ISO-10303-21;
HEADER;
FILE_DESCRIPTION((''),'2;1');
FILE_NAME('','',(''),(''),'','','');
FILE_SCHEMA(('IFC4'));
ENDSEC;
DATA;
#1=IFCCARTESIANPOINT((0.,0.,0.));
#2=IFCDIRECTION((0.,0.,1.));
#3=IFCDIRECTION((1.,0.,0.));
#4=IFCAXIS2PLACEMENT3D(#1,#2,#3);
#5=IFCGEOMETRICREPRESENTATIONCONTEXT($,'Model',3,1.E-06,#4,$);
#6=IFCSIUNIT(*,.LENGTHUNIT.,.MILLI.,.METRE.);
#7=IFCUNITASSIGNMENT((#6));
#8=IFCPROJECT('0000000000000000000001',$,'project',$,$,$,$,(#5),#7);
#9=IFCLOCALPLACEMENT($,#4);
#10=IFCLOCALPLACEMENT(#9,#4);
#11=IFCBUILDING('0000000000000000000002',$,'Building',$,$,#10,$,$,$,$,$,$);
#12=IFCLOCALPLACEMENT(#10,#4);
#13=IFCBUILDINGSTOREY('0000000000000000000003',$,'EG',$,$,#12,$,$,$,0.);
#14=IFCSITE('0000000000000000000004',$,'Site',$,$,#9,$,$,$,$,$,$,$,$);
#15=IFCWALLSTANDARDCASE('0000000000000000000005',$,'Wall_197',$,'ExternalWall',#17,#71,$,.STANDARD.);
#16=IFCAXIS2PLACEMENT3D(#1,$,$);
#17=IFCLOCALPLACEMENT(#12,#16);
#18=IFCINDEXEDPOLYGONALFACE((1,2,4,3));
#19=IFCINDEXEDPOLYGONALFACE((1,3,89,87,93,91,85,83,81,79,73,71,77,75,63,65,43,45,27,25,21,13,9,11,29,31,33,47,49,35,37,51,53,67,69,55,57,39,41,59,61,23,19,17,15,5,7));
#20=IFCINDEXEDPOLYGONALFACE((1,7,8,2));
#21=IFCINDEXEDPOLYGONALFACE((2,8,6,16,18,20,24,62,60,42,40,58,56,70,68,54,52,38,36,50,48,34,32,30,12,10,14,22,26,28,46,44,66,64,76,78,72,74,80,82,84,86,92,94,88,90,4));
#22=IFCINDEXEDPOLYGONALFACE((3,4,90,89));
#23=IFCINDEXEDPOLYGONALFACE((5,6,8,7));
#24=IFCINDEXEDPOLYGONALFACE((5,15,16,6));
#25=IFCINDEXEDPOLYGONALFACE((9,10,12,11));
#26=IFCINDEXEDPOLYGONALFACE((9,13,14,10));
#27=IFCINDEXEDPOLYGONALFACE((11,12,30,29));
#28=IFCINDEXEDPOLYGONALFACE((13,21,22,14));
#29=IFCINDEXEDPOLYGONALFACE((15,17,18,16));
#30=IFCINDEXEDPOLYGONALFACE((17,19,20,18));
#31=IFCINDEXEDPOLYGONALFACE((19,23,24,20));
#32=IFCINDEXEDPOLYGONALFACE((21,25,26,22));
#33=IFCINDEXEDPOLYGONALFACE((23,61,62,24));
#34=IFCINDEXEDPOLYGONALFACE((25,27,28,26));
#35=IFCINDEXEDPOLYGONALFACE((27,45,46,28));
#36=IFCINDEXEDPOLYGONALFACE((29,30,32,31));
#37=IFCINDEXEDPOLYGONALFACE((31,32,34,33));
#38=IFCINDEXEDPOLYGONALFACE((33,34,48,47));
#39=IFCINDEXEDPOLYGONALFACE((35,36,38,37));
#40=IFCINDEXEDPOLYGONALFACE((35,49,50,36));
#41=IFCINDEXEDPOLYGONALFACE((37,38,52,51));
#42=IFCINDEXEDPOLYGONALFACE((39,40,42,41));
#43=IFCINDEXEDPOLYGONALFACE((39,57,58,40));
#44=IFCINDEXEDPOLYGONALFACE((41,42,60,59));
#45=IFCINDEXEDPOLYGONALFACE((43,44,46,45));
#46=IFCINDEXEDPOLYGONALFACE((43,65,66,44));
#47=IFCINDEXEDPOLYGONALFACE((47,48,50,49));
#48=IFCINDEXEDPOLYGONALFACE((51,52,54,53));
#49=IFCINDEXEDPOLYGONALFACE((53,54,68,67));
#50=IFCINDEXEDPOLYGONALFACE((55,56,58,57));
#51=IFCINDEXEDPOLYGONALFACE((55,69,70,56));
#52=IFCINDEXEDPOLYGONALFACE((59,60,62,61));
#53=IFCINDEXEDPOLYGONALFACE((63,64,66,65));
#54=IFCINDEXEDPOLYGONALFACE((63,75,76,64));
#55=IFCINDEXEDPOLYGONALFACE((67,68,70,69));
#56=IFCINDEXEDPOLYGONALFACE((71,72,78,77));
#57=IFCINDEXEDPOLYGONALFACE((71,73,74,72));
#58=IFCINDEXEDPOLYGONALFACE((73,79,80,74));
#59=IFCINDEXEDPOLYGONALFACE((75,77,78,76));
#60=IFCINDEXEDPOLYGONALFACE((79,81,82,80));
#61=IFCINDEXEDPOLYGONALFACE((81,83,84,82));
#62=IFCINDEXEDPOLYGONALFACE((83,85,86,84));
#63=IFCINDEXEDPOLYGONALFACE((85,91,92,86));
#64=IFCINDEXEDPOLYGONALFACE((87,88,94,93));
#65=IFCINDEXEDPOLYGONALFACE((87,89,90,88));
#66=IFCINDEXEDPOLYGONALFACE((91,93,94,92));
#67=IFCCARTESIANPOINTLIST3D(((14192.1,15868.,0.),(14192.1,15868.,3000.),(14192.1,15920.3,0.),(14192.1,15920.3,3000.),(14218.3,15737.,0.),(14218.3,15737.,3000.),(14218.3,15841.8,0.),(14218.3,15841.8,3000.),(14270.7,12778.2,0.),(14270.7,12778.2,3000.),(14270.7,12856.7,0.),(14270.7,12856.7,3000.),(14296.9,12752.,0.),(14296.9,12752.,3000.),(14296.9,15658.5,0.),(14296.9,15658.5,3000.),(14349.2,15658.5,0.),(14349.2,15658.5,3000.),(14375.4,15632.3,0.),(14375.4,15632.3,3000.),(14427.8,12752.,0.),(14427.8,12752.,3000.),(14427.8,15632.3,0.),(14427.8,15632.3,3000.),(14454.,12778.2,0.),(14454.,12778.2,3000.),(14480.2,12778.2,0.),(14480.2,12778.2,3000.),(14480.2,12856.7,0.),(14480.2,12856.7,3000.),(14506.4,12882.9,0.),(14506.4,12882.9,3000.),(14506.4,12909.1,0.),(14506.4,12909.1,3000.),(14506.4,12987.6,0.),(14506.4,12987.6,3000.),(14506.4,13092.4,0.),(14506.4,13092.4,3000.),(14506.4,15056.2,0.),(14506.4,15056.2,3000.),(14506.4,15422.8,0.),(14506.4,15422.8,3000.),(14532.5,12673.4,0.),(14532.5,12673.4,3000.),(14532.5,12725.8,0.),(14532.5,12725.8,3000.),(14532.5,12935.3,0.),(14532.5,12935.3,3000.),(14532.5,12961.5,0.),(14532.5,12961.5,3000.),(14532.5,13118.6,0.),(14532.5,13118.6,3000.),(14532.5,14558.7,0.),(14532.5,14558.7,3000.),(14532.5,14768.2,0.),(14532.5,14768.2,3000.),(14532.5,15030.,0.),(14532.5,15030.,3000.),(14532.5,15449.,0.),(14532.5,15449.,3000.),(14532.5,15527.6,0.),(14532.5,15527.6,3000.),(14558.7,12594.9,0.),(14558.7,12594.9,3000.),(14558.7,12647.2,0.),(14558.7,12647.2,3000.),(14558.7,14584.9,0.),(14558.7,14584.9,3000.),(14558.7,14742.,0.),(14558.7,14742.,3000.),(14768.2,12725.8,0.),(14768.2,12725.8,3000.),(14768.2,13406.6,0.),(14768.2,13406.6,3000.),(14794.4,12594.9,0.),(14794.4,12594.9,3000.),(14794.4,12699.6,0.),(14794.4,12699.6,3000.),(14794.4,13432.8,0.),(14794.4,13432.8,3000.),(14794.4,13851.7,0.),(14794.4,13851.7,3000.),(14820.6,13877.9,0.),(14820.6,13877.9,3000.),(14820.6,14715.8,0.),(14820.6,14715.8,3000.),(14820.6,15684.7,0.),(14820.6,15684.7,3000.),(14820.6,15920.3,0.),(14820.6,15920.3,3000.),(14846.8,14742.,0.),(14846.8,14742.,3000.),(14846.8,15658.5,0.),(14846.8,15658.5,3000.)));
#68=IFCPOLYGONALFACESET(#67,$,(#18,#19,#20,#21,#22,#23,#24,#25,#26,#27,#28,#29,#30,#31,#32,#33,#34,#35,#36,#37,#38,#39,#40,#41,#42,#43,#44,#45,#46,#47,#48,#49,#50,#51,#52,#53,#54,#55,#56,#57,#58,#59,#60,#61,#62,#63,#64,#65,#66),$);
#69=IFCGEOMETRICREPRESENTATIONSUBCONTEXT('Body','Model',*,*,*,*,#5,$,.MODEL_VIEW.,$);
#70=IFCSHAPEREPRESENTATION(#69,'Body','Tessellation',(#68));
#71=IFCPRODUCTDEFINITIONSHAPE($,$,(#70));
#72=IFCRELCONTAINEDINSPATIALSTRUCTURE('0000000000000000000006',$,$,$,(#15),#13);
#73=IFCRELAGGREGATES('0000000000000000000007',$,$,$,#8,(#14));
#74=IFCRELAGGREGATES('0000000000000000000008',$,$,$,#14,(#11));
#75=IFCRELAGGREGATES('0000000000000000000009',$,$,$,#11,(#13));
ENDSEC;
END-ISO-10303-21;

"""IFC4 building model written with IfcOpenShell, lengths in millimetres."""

from ifc_helpers import new_model, si_unit, origin_with_axes, place, context, subcontext, project, spatial, polyline, outline, extrude, element, save


model = new_model("IFC4")

# Units and contexts
model_context = context("Model", 3, precision=1e-06, world=origin_with_axes())
body_context = subcontext(model_context, "Body", "Model", "MODEL_VIEW")
ifc_project = project(units=[si_unit("LENGTHUNIT", "METRE", prefix="MILLI")], contexts=[model_context])

# Site, building, storey
site_placement = place(None, origin_with_axes())
site = spatial("IfcSite", under=ifc_project, at=site_placement, Name="Site")
building_placement = place(site_placement, origin_with_axes())
building = spatial("IfcBuilding", under=site, at=building_placement, Name="Building")
storey_placement = place(building_placement, origin_with_axes())
storey = spatial("IfcBuildingStorey", under=building, at=storey_placement, Name="EG", Elevation=0.0)

# Wall
wall_1_placement = place(storey_placement, origin_with_axes())
element("IfcWallStandardCase", 1, at=wall_1_placement, inside=storey, Name="Wall_197", ObjectType="ExternalWall", PredefinedType="STANDARD", context=body_context, shape_type="SweptSolid", body=[
    extrude(outline(polyline([(14558.7, 12594.9, 0.0), (14558.7, 12647.2, 0.0), (14532.5, 12673.4, 0.0), (14532.5, 12725.8, 0.0), (14480.2, 12778.2, 0.0), (14454.0, 12778.2, 0.0), (14427.8, 12752.0, 0.0), (14296.9, 12752.0, 0.0), (14270.7, 12778.2, 0.0), (14270.7, 12856.7, 0.0), (14480.2, 12856.7, 0.0), (14506.4, 12882.9, 0.0), (14506.4, 12909.1, 0.0), (14532.5, 12935.3, 0.0), (14532.5, 12961.5, 0.0), (14506.4, 12987.6, 0.0), (14506.4, 13092.4, 0.0), (14532.5, 13118.6, 0.0), (14532.5, 14558.7, 0.0), (14558.7, 14584.9, 0.0), (14558.7, 14742.0, 0.0), (14532.5, 14768.2, 0.0), (14532.5, 15030.0, 0.0), (14506.4, 15056.2, 0.0), (14506.4, 15422.8, 0.0), (14532.5, 15449.0, 0.0), (14532.5, 15527.6, 0.0), (14427.8, 15632.3, 0.0), (14375.4, 15632.3, 0.0), (14349.2, 15658.5, 0.0), (14296.9, 15658.5, 0.0), (14218.3, 15737.0, 0.0), (14218.3, 15841.8, 0.0), (14192.1, 15868.0, 0.0), (14192.1, 15920.3, 0.0), (14820.6, 15920.3, 0.0), (14820.6, 15684.7, 0.0), (14846.8, 15658.5, 0.0), (14846.8, 14742.0, 0.0), (14820.6, 14715.8, 0.0), (14820.6, 13877.9, 0.0), (14794.4, 13851.7, 0.0), (14794.4, 13432.8, 0.0), (14768.2, 13406.6, 0.0), (14768.2, 12725.8, 0.0), (14794.4, 12699.6, 0.0), (14794.4, 12594.9, 0.0), (14558.7, 12594.9, 0.0)])), origin_with_axes(), (0.0, 0.0, 1.0), 3000.0),
])

save(model, "model.ifc")
